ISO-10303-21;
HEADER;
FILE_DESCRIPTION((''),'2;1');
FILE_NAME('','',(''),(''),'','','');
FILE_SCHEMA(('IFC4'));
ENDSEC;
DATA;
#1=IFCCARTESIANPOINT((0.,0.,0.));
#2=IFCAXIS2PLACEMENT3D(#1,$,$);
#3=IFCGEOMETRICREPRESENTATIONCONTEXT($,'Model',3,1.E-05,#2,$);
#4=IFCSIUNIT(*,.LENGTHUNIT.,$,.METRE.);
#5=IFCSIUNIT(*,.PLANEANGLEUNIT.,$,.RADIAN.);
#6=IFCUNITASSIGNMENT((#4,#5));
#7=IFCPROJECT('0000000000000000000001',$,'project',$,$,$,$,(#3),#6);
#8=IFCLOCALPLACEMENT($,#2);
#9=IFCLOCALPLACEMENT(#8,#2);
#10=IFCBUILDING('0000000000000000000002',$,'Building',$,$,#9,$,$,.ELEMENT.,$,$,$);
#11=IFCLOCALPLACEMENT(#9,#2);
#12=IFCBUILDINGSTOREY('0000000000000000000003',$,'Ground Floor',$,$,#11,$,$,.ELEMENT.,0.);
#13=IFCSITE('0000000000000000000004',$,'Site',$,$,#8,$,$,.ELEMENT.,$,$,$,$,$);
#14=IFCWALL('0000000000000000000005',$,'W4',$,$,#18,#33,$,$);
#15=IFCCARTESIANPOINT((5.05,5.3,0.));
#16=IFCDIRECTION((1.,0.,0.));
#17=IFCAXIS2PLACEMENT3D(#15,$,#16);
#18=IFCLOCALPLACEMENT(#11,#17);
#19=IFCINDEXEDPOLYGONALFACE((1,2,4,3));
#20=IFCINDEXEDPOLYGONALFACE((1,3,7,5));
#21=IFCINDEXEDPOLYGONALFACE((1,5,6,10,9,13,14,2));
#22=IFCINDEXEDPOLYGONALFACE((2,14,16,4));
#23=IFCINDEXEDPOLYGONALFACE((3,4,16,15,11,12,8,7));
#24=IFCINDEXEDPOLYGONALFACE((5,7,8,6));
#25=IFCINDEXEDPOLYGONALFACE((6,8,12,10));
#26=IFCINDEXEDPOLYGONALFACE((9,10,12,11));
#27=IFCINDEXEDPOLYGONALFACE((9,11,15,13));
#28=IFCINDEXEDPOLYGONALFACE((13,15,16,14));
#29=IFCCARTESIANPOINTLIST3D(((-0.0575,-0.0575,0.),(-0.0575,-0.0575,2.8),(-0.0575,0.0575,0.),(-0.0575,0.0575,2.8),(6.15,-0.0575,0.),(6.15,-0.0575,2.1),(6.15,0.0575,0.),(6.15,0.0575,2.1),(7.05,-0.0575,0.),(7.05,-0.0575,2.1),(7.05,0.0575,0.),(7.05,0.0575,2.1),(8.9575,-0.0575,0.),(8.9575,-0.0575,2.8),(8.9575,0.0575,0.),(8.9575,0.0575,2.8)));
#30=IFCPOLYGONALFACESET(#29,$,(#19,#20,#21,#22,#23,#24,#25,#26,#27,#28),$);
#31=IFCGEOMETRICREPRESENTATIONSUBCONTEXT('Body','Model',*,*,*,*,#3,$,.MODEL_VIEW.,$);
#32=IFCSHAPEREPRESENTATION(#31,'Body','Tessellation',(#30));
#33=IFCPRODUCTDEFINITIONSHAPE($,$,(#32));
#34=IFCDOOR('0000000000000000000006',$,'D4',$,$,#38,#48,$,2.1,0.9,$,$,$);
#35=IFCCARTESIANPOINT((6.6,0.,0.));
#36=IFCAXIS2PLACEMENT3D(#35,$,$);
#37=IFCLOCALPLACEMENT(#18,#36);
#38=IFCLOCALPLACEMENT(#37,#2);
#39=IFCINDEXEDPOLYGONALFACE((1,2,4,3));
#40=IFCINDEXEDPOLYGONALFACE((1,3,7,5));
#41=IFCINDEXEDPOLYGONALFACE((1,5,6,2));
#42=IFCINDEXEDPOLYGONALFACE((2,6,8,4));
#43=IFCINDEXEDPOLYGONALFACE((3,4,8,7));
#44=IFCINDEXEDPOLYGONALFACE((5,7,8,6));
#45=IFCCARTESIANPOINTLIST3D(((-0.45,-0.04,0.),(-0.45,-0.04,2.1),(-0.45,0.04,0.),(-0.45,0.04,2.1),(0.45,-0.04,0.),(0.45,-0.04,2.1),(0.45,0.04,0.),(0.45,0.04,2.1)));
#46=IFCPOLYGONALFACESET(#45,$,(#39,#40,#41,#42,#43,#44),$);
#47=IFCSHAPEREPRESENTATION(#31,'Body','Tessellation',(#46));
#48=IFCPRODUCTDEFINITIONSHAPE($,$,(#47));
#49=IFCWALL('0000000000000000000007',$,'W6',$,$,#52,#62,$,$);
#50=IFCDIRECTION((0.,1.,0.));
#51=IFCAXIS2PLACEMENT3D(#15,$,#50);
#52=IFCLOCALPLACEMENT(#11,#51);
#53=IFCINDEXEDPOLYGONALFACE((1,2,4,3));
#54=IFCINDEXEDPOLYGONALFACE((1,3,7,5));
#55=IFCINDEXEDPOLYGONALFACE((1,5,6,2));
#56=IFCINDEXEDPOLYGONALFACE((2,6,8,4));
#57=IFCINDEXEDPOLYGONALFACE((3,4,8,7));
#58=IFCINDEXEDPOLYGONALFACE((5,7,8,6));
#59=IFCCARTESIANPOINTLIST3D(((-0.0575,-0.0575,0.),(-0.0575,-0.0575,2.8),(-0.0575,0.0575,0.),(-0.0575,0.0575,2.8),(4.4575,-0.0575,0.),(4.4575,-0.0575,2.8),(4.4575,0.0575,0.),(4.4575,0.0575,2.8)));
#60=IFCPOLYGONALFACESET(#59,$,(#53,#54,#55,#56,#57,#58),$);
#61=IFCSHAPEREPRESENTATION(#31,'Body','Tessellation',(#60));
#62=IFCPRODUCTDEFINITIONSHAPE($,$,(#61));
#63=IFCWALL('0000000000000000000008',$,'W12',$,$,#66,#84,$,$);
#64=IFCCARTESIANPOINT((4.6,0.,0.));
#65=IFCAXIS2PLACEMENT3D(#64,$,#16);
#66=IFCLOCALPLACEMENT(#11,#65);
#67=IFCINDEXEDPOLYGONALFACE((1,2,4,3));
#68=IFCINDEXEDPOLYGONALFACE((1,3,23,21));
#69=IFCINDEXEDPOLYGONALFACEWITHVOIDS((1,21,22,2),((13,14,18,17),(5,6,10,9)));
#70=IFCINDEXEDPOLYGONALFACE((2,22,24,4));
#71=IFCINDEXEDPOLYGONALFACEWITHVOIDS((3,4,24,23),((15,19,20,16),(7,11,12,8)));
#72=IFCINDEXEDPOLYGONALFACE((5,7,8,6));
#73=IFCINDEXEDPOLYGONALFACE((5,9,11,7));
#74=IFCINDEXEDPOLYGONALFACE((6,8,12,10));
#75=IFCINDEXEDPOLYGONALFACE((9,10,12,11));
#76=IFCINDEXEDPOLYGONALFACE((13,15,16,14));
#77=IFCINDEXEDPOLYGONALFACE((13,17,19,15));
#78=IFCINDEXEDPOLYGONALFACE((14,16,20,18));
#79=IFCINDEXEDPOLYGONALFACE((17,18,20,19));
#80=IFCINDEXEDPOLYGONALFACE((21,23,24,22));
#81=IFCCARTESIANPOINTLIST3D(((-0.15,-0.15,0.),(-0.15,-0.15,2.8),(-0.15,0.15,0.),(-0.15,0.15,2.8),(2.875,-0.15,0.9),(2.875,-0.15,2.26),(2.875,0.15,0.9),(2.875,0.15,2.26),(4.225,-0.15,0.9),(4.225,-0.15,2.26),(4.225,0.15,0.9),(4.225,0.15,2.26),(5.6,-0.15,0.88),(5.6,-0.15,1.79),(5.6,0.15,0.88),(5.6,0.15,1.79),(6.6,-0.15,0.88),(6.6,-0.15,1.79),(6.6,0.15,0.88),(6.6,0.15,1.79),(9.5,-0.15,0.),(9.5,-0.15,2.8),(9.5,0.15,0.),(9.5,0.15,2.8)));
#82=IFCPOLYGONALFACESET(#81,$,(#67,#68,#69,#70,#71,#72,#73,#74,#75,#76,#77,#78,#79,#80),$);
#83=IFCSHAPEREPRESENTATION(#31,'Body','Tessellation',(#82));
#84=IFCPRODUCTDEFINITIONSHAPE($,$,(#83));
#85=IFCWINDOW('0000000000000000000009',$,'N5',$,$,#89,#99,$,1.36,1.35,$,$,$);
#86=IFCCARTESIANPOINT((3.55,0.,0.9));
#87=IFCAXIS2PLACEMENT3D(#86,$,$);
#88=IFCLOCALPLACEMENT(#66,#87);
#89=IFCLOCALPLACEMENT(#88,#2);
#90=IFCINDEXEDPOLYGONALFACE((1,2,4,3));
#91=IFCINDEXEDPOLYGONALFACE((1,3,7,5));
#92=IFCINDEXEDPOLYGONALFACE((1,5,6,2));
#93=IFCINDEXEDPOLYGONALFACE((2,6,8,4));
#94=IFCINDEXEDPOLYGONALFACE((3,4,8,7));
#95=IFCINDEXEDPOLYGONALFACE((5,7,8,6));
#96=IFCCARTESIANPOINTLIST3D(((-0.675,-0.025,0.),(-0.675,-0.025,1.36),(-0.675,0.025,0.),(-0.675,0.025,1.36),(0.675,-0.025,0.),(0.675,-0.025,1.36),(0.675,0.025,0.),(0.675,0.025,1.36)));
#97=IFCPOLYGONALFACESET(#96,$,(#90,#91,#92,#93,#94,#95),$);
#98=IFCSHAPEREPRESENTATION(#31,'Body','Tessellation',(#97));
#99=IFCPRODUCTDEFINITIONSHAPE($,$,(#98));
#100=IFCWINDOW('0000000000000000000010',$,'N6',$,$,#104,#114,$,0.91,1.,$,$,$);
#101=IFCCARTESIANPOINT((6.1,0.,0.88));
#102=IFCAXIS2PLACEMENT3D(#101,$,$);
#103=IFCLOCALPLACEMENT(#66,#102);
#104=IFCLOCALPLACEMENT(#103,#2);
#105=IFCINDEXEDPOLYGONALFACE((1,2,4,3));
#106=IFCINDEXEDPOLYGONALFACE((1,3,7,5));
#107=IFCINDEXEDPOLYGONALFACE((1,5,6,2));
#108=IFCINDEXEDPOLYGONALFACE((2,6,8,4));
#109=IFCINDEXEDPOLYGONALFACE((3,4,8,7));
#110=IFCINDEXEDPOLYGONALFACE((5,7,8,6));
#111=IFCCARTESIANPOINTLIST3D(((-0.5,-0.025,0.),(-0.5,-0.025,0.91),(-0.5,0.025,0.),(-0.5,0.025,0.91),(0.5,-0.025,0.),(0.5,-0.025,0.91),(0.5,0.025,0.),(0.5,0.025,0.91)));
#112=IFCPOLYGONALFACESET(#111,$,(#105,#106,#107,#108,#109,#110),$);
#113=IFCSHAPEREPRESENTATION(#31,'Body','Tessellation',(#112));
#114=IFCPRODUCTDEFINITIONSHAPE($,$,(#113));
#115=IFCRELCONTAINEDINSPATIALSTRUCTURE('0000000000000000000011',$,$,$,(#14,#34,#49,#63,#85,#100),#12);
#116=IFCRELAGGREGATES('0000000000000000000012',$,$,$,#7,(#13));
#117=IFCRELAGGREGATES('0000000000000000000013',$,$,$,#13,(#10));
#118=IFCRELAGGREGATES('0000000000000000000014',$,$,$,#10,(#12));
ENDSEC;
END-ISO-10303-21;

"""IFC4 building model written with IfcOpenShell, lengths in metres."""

from ifc_helpers import new_model, si_unit, frame, frame_2d, origin, origin_2d, place, context, subcontext, project, spatial, rectangle, extrude, element, fill, save


model = new_model("IFC4")

# Units and contexts
model_context = context("Model", 3, precision=1e-05, world=origin())
body_context = subcontext(model_context, "Body", "Model", "MODEL_VIEW")
ifc_project = project(units=[si_unit("LENGTHUNIT", "METRE"), si_unit("PLANEANGLEUNIT", "RADIAN")], contexts=[model_context])

# Site, building, storey
site_placement = place(None, origin())
site = spatial("IfcSite", under=ifc_project, at=site_placement, Name="Site", CompositionType="ELEMENT")
building_placement = place(site_placement, origin())
building = spatial("IfcBuilding", under=site, at=building_placement, Name="Building", CompositionType="ELEMENT")
storey_placement = place(building_placement, origin())
storey = spatial("IfcBuildingStorey", under=building, at=storey_placement, Name="Ground Floor", CompositionType="ELEMENT", Elevation=0.0)

# Wall, opening, door
wall_1_placement = place(storey_placement, frame((5.05, 5.3, 0.0), x_axis=(1.0, 0.0, 0.0)))
wall_1 = element("IfcWall", 1, at=wall_1_placement, inside=storey, Name="W4", context=body_context, shape_type="SweptSolid", body=[
    extrude(rectangle(XDim=9.015, YDim=0.115, at=frame_2d((4.45, 0.0))), origin(), (0.0, 0.0, 1.0), 2.8),
])
opening_1_placement = place(wall_1_placement, frame((6.6, 0.0, 0.0)))
opening_1 = element("IfcOpeningElement", 2, at=opening_1_placement, cuts=wall_1, context=body_context, shape_type="SweptSolid", body=[
    extrude(rectangle(XDim=0.9, YDim=0.215, at=origin_2d()), origin(), (0.0, 0.0, 1.0), 2.1),
])
door_1_placement = place(opening_1_placement, origin())
door_1 = element("IfcDoor", 3, at=door_1_placement, inside=storey, Name="D4", OverallHeight=2.1, OverallWidth=0.9, context=body_context, shape_type="SweptSolid", body=[
    extrude(rectangle(XDim=0.9, YDim=0.08, at=origin_2d()), origin(), (0.0, 0.0, 1.0), 2.1),
])
fill(opening_1, door_1)

# Wall
wall_2_placement = place(storey_placement, frame((5.05, 5.3, 0.0), x_axis=(0.0, 1.0, 0.0)))
element("IfcWall", 4, at=wall_2_placement, inside=storey, Name="W6", context=body_context, shape_type="SweptSolid", body=[
    extrude(rectangle(XDim=4.515, YDim=0.115, at=frame_2d((2.2, 0.0))), origin(), (0.0, 0.0, 1.0), 2.8),
])

# Wall, openings, windows
wall_3_placement = place(storey_placement, frame((4.6, 0.0, 0.0), x_axis=(1.0, 0.0, 0.0)))
wall_3 = element("IfcWall", 5, at=wall_3_placement, inside=storey, Name="W12", context=body_context, shape_type="SweptSolid", body=[
    extrude(rectangle(XDim=9.65, YDim=0.3, at=frame_2d((4.675, 0.0))), origin(), (0.0, 0.0, 1.0), 2.8),
])
opening_2_placement = place(wall_3_placement, frame((3.55, 0.0, 0.9)))
opening_2 = element("IfcOpeningElement", 6, at=opening_2_placement, cuts=wall_3, context=body_context, shape_type="SweptSolid", body=[
    extrude(rectangle(XDim=1.35, YDim=0.4, at=origin_2d()), origin(), (0.0, 0.0, 1.0), 1.36),
])
opening_3_placement = place(wall_3_placement, frame((6.1, 0.0, 0.88)))
opening_3 = element("IfcOpeningElement", 7, at=opening_3_placement, cuts=wall_3, context=body_context, shape_type="SweptSolid", body=[
    extrude(rectangle(XDim=1.0, YDim=0.4, at=origin_2d()), origin(), (0.0, 0.0, 1.0), 0.91),
])
window_1_placement = place(opening_2_placement, origin())
window_1 = element("IfcWindow", 8, at=window_1_placement, inside=storey, Name="N5", OverallHeight=1.36, OverallWidth=1.35, context=body_context, shape_type="SweptSolid", body=[
    extrude(rectangle(XDim=1.35, YDim=0.05, at=origin_2d()), origin(), (0.0, 0.0, 1.0), 1.36),
])
fill(opening_2, window_1)
window_2_placement = place(opening_3_placement, origin())
window_2 = element("IfcWindow", 9, at=window_2_placement, inside=storey, Name="N6", OverallHeight=0.91, OverallWidth=1.0, context=body_context, shape_type="SweptSolid", body=[
    extrude(rectangle(XDim=1.0, YDim=0.05, at=origin_2d()), origin(), (0.0, 0.0, 1.0), 0.91),
])
fill(opening_3, window_2)

save(model, "model.ifc")
